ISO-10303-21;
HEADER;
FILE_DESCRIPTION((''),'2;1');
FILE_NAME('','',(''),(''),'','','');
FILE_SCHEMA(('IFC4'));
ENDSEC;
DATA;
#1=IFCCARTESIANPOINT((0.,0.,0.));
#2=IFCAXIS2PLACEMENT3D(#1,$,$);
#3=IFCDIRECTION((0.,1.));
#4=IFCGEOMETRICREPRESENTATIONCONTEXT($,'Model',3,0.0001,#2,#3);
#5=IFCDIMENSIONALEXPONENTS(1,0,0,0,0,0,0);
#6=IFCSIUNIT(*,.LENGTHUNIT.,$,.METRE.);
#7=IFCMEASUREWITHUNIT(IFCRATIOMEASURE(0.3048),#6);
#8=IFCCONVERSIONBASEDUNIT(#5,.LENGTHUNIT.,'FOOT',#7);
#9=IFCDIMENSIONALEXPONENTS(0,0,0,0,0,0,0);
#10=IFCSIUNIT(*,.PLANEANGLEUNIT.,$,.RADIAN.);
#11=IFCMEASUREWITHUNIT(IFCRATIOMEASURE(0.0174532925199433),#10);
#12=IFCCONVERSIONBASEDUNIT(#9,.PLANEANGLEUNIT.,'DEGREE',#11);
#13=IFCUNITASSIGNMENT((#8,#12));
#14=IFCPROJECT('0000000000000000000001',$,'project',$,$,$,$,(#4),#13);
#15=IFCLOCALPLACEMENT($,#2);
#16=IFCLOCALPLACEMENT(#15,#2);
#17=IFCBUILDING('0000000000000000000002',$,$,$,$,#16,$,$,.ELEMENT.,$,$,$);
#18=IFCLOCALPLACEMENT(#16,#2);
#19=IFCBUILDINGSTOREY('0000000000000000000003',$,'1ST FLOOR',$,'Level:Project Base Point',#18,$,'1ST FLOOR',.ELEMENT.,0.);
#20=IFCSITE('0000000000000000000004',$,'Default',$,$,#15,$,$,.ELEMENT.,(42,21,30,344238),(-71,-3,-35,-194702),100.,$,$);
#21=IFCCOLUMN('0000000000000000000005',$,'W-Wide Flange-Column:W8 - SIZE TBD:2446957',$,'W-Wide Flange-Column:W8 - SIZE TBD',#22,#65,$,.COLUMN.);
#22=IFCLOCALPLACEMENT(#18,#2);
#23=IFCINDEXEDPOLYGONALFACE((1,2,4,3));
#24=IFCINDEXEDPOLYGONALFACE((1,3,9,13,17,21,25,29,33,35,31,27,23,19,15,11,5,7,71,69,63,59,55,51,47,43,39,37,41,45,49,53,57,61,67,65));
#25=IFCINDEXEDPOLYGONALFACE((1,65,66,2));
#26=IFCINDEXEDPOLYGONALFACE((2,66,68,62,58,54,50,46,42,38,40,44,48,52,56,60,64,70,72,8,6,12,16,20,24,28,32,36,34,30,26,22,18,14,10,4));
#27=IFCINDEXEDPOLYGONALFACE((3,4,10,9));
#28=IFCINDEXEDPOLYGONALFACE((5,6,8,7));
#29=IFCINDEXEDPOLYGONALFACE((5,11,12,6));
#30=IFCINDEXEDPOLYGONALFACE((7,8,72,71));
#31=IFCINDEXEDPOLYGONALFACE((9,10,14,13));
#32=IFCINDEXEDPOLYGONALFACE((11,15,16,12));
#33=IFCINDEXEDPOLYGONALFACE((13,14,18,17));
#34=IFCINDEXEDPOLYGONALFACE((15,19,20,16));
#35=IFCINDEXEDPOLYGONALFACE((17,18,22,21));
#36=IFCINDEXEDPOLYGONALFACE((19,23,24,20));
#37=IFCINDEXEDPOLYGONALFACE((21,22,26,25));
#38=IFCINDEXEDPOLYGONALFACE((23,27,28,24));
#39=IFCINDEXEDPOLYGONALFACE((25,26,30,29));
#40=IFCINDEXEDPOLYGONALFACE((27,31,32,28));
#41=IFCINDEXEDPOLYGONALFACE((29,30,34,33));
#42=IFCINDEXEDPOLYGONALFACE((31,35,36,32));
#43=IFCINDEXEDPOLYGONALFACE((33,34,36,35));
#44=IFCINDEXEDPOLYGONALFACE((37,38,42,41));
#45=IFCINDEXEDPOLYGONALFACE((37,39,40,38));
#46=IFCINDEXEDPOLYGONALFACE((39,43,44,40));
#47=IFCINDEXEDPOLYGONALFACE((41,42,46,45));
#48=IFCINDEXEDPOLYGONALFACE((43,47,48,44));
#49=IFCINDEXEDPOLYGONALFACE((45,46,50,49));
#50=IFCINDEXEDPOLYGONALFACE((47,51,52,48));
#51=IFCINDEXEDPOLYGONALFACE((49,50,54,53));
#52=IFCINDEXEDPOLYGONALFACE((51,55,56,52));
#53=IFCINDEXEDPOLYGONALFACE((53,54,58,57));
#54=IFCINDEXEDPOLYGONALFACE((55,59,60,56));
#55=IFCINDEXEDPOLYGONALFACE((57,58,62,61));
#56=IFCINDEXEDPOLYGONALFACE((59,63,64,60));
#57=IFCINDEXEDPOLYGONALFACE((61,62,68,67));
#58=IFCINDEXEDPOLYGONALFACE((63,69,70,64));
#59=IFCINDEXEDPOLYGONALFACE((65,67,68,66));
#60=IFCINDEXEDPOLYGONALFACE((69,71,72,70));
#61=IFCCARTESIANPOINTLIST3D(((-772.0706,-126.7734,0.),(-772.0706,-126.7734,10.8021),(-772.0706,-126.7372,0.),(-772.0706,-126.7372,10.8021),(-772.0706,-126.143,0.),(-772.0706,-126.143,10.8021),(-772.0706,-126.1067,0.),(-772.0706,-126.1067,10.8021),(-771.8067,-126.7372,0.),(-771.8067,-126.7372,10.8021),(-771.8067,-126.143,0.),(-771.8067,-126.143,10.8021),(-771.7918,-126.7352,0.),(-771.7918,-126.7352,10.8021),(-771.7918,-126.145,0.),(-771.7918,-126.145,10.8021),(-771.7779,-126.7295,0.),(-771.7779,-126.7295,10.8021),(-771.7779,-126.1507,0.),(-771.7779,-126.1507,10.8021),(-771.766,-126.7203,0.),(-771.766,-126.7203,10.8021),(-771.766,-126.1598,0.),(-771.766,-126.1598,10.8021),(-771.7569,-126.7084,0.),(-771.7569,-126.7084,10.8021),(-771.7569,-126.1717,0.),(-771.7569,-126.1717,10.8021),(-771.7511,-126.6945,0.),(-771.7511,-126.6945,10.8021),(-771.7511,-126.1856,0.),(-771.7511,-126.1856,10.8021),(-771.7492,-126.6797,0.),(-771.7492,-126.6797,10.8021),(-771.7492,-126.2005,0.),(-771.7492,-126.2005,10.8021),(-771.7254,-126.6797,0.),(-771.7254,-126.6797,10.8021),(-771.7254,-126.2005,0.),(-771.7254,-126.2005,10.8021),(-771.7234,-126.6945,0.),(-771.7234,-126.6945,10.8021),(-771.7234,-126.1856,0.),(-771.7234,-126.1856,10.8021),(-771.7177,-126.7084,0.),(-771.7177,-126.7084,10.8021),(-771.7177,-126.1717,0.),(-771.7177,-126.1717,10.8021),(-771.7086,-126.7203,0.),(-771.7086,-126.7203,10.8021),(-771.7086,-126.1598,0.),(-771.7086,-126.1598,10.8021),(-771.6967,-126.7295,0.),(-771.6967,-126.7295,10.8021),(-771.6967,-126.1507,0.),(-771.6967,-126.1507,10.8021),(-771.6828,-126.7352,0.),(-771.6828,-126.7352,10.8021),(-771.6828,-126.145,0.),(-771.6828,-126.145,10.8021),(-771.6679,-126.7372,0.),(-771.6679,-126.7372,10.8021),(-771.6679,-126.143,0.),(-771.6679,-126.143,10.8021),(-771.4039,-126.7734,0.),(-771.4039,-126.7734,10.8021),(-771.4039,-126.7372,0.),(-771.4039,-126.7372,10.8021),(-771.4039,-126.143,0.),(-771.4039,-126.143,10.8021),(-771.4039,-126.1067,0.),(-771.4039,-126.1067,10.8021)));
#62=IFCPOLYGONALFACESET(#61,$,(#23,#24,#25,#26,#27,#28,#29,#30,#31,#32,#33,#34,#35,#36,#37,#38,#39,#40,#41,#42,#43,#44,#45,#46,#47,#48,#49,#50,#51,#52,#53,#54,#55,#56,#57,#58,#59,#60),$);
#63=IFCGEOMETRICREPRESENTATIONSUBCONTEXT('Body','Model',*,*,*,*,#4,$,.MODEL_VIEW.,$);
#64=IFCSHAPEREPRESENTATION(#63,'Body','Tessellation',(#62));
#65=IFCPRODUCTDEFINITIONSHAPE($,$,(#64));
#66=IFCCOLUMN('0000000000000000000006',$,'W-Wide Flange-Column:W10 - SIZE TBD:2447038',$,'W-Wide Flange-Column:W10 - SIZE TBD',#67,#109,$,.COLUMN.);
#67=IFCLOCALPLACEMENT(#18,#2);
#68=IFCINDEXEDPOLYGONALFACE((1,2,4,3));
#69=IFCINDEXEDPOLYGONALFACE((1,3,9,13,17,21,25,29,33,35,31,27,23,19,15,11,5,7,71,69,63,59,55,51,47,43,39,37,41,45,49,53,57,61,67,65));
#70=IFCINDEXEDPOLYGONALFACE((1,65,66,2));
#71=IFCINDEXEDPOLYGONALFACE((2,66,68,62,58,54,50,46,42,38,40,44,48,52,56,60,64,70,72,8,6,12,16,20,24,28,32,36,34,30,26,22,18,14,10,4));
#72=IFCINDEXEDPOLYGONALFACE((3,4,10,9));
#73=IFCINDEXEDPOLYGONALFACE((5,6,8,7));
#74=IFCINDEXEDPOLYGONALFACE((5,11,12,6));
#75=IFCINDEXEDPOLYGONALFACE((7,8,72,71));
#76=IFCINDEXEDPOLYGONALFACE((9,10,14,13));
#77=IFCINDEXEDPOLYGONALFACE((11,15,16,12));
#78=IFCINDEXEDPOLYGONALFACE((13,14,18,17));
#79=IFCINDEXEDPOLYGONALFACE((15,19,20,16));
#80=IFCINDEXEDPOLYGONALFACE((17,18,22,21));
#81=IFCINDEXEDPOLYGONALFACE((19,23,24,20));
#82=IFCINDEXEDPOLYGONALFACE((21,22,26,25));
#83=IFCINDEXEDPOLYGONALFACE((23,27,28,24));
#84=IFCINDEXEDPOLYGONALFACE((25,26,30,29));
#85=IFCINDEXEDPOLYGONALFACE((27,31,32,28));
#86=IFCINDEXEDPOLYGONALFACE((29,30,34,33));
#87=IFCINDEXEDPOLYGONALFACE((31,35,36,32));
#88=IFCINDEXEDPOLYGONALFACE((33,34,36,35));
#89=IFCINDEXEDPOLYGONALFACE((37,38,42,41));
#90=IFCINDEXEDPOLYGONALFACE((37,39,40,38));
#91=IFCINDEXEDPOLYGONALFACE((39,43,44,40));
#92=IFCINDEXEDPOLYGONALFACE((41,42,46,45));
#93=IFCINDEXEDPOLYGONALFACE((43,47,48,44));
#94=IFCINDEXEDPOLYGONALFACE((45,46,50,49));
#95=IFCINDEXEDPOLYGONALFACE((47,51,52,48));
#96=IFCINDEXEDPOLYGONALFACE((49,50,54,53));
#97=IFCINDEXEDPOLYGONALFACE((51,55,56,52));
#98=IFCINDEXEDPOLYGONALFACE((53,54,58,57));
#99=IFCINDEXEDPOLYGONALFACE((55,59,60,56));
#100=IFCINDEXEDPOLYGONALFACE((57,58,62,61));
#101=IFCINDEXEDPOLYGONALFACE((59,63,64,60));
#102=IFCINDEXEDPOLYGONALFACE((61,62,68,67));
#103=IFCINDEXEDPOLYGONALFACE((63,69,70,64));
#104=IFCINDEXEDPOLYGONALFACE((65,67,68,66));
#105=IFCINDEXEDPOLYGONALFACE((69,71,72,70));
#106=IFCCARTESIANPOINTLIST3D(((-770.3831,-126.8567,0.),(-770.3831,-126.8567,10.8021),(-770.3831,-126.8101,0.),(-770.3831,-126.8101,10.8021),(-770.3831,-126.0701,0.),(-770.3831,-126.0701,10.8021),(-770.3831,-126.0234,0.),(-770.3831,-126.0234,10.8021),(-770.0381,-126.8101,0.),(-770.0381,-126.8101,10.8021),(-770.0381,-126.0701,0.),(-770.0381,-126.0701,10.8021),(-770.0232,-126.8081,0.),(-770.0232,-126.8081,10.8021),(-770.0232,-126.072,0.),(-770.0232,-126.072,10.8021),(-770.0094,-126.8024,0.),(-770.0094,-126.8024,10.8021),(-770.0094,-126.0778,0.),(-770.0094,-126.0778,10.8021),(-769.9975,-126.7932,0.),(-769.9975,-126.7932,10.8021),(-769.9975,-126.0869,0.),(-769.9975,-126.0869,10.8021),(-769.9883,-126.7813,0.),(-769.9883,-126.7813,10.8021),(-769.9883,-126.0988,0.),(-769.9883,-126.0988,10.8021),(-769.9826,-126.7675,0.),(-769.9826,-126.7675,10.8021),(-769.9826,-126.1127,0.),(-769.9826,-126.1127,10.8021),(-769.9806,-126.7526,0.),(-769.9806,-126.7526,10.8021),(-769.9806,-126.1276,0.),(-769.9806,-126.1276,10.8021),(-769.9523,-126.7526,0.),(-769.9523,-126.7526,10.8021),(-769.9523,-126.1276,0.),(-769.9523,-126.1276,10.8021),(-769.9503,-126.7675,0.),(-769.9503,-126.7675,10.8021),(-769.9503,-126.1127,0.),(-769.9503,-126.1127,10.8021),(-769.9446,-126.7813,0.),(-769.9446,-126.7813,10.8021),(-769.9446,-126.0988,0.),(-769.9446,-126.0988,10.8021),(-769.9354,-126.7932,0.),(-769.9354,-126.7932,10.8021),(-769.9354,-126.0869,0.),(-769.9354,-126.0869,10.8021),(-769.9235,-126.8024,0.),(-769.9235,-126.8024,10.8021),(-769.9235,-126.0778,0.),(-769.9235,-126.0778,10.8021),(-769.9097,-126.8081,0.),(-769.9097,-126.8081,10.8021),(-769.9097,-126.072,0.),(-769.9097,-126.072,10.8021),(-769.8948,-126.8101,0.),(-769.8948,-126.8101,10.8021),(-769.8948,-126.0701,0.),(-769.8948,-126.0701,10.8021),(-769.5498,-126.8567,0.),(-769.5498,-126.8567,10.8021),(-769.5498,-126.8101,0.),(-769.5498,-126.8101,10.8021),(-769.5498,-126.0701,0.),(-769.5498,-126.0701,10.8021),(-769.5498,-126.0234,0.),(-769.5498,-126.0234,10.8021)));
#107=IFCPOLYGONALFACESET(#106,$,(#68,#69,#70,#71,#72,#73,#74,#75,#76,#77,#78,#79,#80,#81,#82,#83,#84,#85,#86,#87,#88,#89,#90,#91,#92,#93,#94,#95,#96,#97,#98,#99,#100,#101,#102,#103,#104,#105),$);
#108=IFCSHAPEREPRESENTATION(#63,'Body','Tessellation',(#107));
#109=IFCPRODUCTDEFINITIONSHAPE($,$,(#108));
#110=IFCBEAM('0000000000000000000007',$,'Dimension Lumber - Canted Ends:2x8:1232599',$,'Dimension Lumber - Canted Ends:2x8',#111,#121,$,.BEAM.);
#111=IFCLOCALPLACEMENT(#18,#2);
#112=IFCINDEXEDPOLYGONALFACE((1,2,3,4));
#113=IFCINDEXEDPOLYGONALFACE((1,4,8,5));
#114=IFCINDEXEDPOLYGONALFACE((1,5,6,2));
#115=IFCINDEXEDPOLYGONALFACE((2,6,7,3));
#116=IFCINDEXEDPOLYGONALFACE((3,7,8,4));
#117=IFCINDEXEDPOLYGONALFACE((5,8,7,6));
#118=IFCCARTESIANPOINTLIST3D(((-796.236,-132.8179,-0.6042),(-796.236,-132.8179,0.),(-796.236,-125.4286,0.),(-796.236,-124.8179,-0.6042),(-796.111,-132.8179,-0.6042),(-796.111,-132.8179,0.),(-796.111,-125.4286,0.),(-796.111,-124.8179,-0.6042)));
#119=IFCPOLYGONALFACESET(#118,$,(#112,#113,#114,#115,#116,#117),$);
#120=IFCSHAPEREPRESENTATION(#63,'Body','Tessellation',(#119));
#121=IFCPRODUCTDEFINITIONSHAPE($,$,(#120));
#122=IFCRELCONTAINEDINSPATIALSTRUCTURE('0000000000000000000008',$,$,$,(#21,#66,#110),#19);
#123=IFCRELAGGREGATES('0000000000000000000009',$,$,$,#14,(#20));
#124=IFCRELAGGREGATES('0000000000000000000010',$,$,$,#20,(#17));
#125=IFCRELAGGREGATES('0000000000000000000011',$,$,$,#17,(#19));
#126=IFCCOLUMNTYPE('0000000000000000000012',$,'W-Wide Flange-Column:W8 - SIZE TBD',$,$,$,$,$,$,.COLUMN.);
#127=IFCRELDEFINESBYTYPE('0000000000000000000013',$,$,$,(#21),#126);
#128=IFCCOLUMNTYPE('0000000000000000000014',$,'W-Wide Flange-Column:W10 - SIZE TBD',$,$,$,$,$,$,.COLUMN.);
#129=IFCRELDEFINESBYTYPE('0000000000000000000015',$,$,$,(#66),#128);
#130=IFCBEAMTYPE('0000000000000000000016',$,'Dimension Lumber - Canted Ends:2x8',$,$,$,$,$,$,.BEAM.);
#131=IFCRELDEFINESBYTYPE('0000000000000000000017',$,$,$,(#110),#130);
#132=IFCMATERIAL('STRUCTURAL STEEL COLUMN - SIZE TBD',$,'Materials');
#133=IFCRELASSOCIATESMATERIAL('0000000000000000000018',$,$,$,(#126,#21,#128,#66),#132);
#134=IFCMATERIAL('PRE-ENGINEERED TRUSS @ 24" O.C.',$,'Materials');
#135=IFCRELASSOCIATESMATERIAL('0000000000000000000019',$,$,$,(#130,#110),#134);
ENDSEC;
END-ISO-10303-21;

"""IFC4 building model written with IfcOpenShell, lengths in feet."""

from ifc_helpers import new_model, entity, si_unit, converted_unit, direction, frame, frame_2d, origin, origin_2d_with_axis, place, context, subcontext, project, spatial, polyline, circle_curve, parameter, trimmed, segment, composite_curve, rectangle, outline, extrude, clip, halfspace, source, transform, mapped, material, material_profile, profile_set, profile_usage, type_object, type_shapes, element, save


model = new_model("IFC4")

# Units and contexts
model_context = context("Model", 3, precision=0.0001, world=origin(), true_north=direction((0.0, 1.0)))
body_context = subcontext(model_context, "Body", "Model", "MODEL_VIEW")
ifc_project = project(units=[converted_unit("LENGTHUNIT", "FOOT", entity("IfcRatioMeasure", 0.3048), si_unit("LENGTHUNIT", "METRE"), dimensions=[1, 0, 0, 0, 0, 0, 0]), converted_unit("PLANEANGLEUNIT", "DEGREE", entity("IfcRatioMeasure", 0.0174532925199433), si_unit("PLANEANGLEUNIT", "RADIAN"), dimensions=[0, 0, 0, 0, 0, 0, 0])], contexts=[model_context])

# Site, building, storey
site_placement = place(None, origin())
site = spatial("IfcSite", under=ifc_project, at=site_placement, Name="Default", CompositionType="ELEMENT", RefLatitude=(42, 21, 30, 344238), RefLongitude=(-71, -3, -35, -194702), RefElevation=100.0)
building_placement = place(site_placement, origin())
building = spatial("IfcBuilding", under=site, at=building_placement, CompositionType="ELEMENT")
storey_placement = place(building_placement, origin())
storey = spatial("IfcBuildingStorey", under=building, at=storey_placement, Name="1ST FLOOR", ObjectType="Level:Project Base Point", LongName="1ST FLOOR", CompositionType="ELEMENT", Elevation=0.0)

# Columns
ifc_material_1 = material(Name="STRUCTURAL STEEL COLUMN - SIZE TBD", Category="Materials")
ifc_material_profile_1 = material_profile(ifc_material_1, outline(composite_curve([segment(polyline([(0.2971, -0.3333), (0.3333, -0.3333)]), True, "CONTINUOUS"), segment(polyline([(0.3333, -0.3333), (0.3333, 0.3333)]), True, "CONTINUOUS"), segment(polyline([(0.3333, 0.3333), (0.2971, 0.3333)]), True, "CONTINUOUS"), segment(polyline([(0.2971, 0.3333), (0.2971, 0.0694)]), True, "CONTINUOUS"), segment(trimmed(circle_curve(frame_2d((0.2396, 0.0694), x_axis=(1.0, 0.0)), 0.0575), [parameter(270.0)], [parameter(0.0)], True, "PARAMETER"), False, "CONTINUOUS"), segment(polyline([(0.2396, 0.0119), (-0.2396, 0.0119)]), True, "CONTINUOUS"), segment(trimmed(circle_curve(frame_2d((-0.2396, 0.0694), x_axis=(0.0, -1.0)), 0.0575), [parameter(270.0)], [parameter(0.0)], True, "PARAMETER"), False, "CONTINUOUS"), segment(polyline([(-0.2971, 0.0694), (-0.2971, 0.3333)]), True, "CONTINUOUS"), segment(polyline([(-0.2971, 0.3333), (-0.3333, 0.3333)]), True, "CONTINUOUS"), segment(polyline([(-0.3333, 0.3333), (-0.3333, -0.3333)]), True, "CONTINUOUS"), segment(polyline([(-0.3333, -0.3333), (-0.2971, -0.3333)]), True, "CONTINUOUS"), segment(polyline([(-0.2971, -0.3333), (-0.2971, -0.0694)]), True, "CONTINUOUS"), segment(trimmed(circle_curve(frame_2d((-0.2396, -0.0694), x_axis=(-1.0, 0.0)), 0.0575), [parameter(270.0)], [parameter(0.0)], True, "PARAMETER"), False, "CONTINUOUS"), segment(polyline([(-0.2396, -0.0119), (0.2396, -0.0119)]), True, "CONTINUOUS"), segment(trimmed(circle_curve(frame_2d((0.2396, -0.0694), x_axis=(0.0, 1.0)), 0.0575), [parameter(270.0)], [parameter(0.0)], True, "PARAMETER"), False, "CONTINUOUS"), segment(polyline([(0.2971, -0.0694), (0.2971, -0.3333)]), True, "CONTINUOUS")], self_intersect=False)), Name="W8 - SIZE TBD")
ifc_profile_set_1 = profile_set([ifc_material_profile_1], Name="W8 - SIZE TBD")
ifc_profile_usage_1 = profile_usage(ifc_profile_set_1)
column_type_1 = type_object("IfcColumnType", Name="W-Wide Flange-Column:W8 - SIZE TBD", PredefinedType="COLUMN", material=ifc_profile_set_1)
shared_shape_1 = source(origin(), body_context, "Body", "SweptSolid", [
    extrude(outline(composite_curve([segment(polyline([(0.2971, -0.3333), (0.3333, -0.3333)]), True, "CONTINUOUS"), segment(polyline([(0.3333, -0.3333), (0.3333, 0.3333)]), True, "CONTINUOUS"), segment(polyline([(0.3333, 0.3333), (0.2971, 0.3333)]), True, "CONTINUOUS"), segment(polyline([(0.2971, 0.3333), (0.2971, 0.0694)]), True, "CONTINUOUS"), segment(trimmed(circle_curve(frame_2d((0.2396, 0.0694), x_axis=(1.0, 0.0)), 0.0575), [parameter(270.0)], [parameter(0.0)], True, "PARAMETER"), False, "CONTINUOUS"), segment(polyline([(0.2396, 0.0119), (-0.2396, 0.0119)]), True, "CONTINUOUS"), segment(trimmed(circle_curve(frame_2d((-0.2396, 0.0694), x_axis=(0.0, -1.0)), 0.0575), [parameter(270.0)], [parameter(0.0)], True, "PARAMETER"), False, "CONTINUOUS"), segment(polyline([(-0.2971, 0.0694), (-0.2971, 0.3333)]), True, "CONTINUOUS"), segment(polyline([(-0.2971, 0.3333), (-0.3333, 0.3333)]), True, "CONTINUOUS"), segment(polyline([(-0.3333, 0.3333), (-0.3333, -0.3333)]), True, "CONTINUOUS"), segment(polyline([(-0.3333, -0.3333), (-0.2971, -0.3333)]), True, "CONTINUOUS"), segment(polyline([(-0.2971, -0.3333), (-0.2971, -0.0694)]), True, "CONTINUOUS"), segment(trimmed(circle_curve(frame_2d((-0.2396, -0.0694), x_axis=(-1.0, 0.0)), 0.0575), [parameter(270.0)], [parameter(0.0)], True, "PARAMETER"), False, "CONTINUOUS"), segment(polyline([(-0.2396, -0.0119), (0.2396, -0.0119)]), True, "CONTINUOUS"), segment(trimmed(circle_curve(frame_2d((0.2396, -0.0694), x_axis=(0.0, 1.0)), 0.0575), [parameter(270.0)], [parameter(0.0)], True, "PARAMETER"), False, "CONTINUOUS"), segment(polyline([(0.2971, -0.0694), (0.2971, -0.3333)]), True, "CONTINUOUS")], self_intersect=False)), frame((0.0, 0.0, 0.0), z_axis=(0.0, 0.0, 1.0), x_axis=(0.0, -1.0, 0.0)), (0.0, 0.0, 1.0), 10.8021),
])
type_shapes(column_type_1, [shared_shape_1])
column_1_placement = place(storey_placement, frame((-771.7373, -126.4401, 0.0)))
element("IfcColumn", 1, at=column_1_placement, inside=storey, type_object=column_type_1, material=ifc_profile_usage_1, Name="W-Wide Flange-Column:W8 - SIZE TBD:2446957", ObjectType="W-Wide Flange-Column:W8 - SIZE TBD", PredefinedType="COLUMN", context=body_context, shape_type="MappedRepresentation", body=[
    mapped(shared_shape_1, transform((0.0, 0.0, 0.0), scale=1.0)),
])
ifc_material_profile_2 = material_profile(ifc_material_1, outline(composite_curve([segment(polyline([(0.37, -0.4167), (0.4167, -0.4167)]), True, "CONTINUOUS"), segment(polyline([(0.4167, -0.4167), (0.4167, 0.4167)]), True, "CONTINUOUS"), segment(polyline([(0.4167, 0.4167), (0.37, 0.4167)]), True, "CONTINUOUS"), segment(polyline([(0.37, 0.4167), (0.37, 0.0717)]), True, "CONTINUOUS"), segment(trimmed(circle_curve(frame_2d((0.3125, 0.0717), x_axis=(1.0, 0.0)), 0.0575), [parameter(270.0)], [parameter(0.0)], True, "PARAMETER"), False, "CONTINUOUS"), segment(polyline([(0.3125, 0.0142), (-0.3125, 0.0142)]), True, "CONTINUOUS"), segment(trimmed(circle_curve(frame_2d((-0.3125, 0.0717), x_axis=(0.0, -1.0)), 0.0575), [parameter(270.0)], [parameter(0.0)], True, "PARAMETER"), False, "CONTINUOUS"), segment(polyline([(-0.37, 0.0717), (-0.37, 0.4167)]), True, "CONTINUOUS"), segment(polyline([(-0.37, 0.4167), (-0.4167, 0.4167)]), True, "CONTINUOUS"), segment(polyline([(-0.4167, 0.4167), (-0.4167, -0.4167)]), True, "CONTINUOUS"), segment(polyline([(-0.4167, -0.4167), (-0.37, -0.4167)]), True, "CONTINUOUS"), segment(polyline([(-0.37, -0.4167), (-0.37, -0.0717)]), True, "CONTINUOUS"), segment(trimmed(circle_curve(frame_2d((-0.3125, -0.0717), x_axis=(-1.0, 0.0)), 0.0575), [parameter(270.0)], [parameter(0.0)], True, "PARAMETER"), False, "CONTINUOUS"), segment(polyline([(-0.3125, -0.0142), (0.3125, -0.0142)]), True, "CONTINUOUS"), segment(trimmed(circle_curve(frame_2d((0.3125, -0.0717), x_axis=(0.0, 1.0)), 0.0575), [parameter(270.0)], [parameter(0.0)], True, "PARAMETER"), False, "CONTINUOUS"), segment(polyline([(0.37, -0.0717), (0.37, -0.4167)]), True, "CONTINUOUS")], self_intersect=False)), Name="W10 - SIZE TBD")
ifc_profile_set_2 = profile_set([ifc_material_profile_2], Name="W10 - SIZE TBD")
ifc_profile_usage_2 = profile_usage(ifc_profile_set_2)
column_type_2 = type_object("IfcColumnType", Name="W-Wide Flange-Column:W10 - SIZE TBD", PredefinedType="COLUMN", material=ifc_profile_set_2)
shared_shape_2 = source(origin(), body_context, "Body", "SweptSolid", [
    extrude(outline(composite_curve([segment(polyline([(0.37, -0.4167), (0.4167, -0.4167)]), True, "CONTINUOUS"), segment(polyline([(0.4167, -0.4167), (0.4167, 0.4167)]), True, "CONTINUOUS"), segment(polyline([(0.4167, 0.4167), (0.37, 0.4167)]), True, "CONTINUOUS"), segment(polyline([(0.37, 0.4167), (0.37, 0.0717)]), True, "CONTINUOUS"), segment(trimmed(circle_curve(frame_2d((0.3125, 0.0717), x_axis=(1.0, 0.0)), 0.0575), [parameter(270.0)], [parameter(0.0)], True, "PARAMETER"), False, "CONTINUOUS"), segment(polyline([(0.3125, 0.0142), (-0.3125, 0.0142)]), True, "CONTINUOUS"), segment(trimmed(circle_curve(frame_2d((-0.3125, 0.0717), x_axis=(0.0, -1.0)), 0.0575), [parameter(270.0)], [parameter(0.0)], True, "PARAMETER"), False, "CONTINUOUS"), segment(polyline([(-0.37, 0.0717), (-0.37, 0.4167)]), True, "CONTINUOUS"), segment(polyline([(-0.37, 0.4167), (-0.4167, 0.4167)]), True, "CONTINUOUS"), segment(polyline([(-0.4167, 0.4167), (-0.4167, -0.4167)]), True, "CONTINUOUS"), segment(polyline([(-0.4167, -0.4167), (-0.37, -0.4167)]), True, "CONTINUOUS"), segment(polyline([(-0.37, -0.4167), (-0.37, -0.0717)]), True, "CONTINUOUS"), segment(trimmed(circle_curve(frame_2d((-0.3125, -0.0717), x_axis=(-1.0, 0.0)), 0.0575), [parameter(270.0)], [parameter(0.0)], True, "PARAMETER"), False, "CONTINUOUS"), segment(polyline([(-0.3125, -0.0142), (0.3125, -0.0142)]), True, "CONTINUOUS"), segment(trimmed(circle_curve(frame_2d((0.3125, -0.0717), x_axis=(0.0, 1.0)), 0.0575), [parameter(270.0)], [parameter(0.0)], True, "PARAMETER"), False, "CONTINUOUS"), segment(polyline([(0.37, -0.0717), (0.37, -0.4167)]), True, "CONTINUOUS")], self_intersect=False)), frame((0.0, 0.0, 0.0), z_axis=(0.0, 0.0, 1.0), x_axis=(0.0, -1.0, 0.0)), (0.0, 0.0, 1.0), 10.8021),
])
type_shapes(column_type_2, [shared_shape_2])
column_2_placement = place(storey_placement, frame((-769.9664, -126.4401, 0.0)))
element("IfcColumn", 2, at=column_2_placement, inside=storey, type_object=column_type_2, material=ifc_profile_usage_2, Name="W-Wide Flange-Column:W10 - SIZE TBD:2447038", ObjectType="W-Wide Flange-Column:W10 - SIZE TBD", PredefinedType="COLUMN", context=body_context, shape_type="MappedRepresentation", body=[
    mapped(shared_shape_2, transform((0.0, 0.0, 0.0), scale=1.0)),
])

# Beam
ifc_material_2 = material(Name="PRE-ENGINEERED TRUSS @ 24\" O.C.", Category="Materials")
ifc_material_profile_3 = material_profile(ifc_material_2, rectangle(XDim=0.6042, YDim=0.125, at=origin_2d_with_axis()), Name="2x8")
ifc_profile_set_3 = profile_set([ifc_material_profile_3], Name="2x8")
ifc_profile_usage_3 = profile_usage(ifc_profile_set_3, cardinal=8)
beam_type_1 = type_object("IfcBeamType", Name="Dimension Lumber - Canted Ends:2x8", PredefinedType="BEAM", material=ifc_profile_set_3)
shared_shape_3 = source(origin(), body_context, "Body", "Clipping", [
    clip(extrude(rectangle(XDim=0.6042, YDim=0.125, at=origin_2d_with_axis()), frame((-4.0, 0.0, 0.0), z_axis=(1.0, 0.0, 0.0), x_axis=(0.0, 0.0, -1.0)), (0.0, 0.0, 1.0), 8.0), halfspace(frame((-3.3893, -0.0625, 0.3021), z_axis=(-0.703278, 0.0, 0.710915), x_axis=(0.0, 1.0, 0.0)), False)),
])
type_shapes(beam_type_1, [shared_shape_3])
beam_1_placement = place(storey_placement, frame((-796.1735, -128.8179, -0.3021), z_axis=(0.0, 0.0, 1.0), x_axis=(0.0, -1.0, 0.0)))
element("IfcBeam", 3, at=beam_1_placement, inside=storey, type_object=beam_type_1, material=ifc_profile_usage_3, Name="Dimension Lumber - Canted Ends:2x8:1232599", ObjectType="Dimension Lumber - Canted Ends:2x8", PredefinedType="BEAM", context=body_context, shape_type="MappedRepresentation", body=[
    mapped(shared_shape_3, transform((0.0, 0.0, 0.0), scale=1.0)),
])

save(model, "model.ifc")
